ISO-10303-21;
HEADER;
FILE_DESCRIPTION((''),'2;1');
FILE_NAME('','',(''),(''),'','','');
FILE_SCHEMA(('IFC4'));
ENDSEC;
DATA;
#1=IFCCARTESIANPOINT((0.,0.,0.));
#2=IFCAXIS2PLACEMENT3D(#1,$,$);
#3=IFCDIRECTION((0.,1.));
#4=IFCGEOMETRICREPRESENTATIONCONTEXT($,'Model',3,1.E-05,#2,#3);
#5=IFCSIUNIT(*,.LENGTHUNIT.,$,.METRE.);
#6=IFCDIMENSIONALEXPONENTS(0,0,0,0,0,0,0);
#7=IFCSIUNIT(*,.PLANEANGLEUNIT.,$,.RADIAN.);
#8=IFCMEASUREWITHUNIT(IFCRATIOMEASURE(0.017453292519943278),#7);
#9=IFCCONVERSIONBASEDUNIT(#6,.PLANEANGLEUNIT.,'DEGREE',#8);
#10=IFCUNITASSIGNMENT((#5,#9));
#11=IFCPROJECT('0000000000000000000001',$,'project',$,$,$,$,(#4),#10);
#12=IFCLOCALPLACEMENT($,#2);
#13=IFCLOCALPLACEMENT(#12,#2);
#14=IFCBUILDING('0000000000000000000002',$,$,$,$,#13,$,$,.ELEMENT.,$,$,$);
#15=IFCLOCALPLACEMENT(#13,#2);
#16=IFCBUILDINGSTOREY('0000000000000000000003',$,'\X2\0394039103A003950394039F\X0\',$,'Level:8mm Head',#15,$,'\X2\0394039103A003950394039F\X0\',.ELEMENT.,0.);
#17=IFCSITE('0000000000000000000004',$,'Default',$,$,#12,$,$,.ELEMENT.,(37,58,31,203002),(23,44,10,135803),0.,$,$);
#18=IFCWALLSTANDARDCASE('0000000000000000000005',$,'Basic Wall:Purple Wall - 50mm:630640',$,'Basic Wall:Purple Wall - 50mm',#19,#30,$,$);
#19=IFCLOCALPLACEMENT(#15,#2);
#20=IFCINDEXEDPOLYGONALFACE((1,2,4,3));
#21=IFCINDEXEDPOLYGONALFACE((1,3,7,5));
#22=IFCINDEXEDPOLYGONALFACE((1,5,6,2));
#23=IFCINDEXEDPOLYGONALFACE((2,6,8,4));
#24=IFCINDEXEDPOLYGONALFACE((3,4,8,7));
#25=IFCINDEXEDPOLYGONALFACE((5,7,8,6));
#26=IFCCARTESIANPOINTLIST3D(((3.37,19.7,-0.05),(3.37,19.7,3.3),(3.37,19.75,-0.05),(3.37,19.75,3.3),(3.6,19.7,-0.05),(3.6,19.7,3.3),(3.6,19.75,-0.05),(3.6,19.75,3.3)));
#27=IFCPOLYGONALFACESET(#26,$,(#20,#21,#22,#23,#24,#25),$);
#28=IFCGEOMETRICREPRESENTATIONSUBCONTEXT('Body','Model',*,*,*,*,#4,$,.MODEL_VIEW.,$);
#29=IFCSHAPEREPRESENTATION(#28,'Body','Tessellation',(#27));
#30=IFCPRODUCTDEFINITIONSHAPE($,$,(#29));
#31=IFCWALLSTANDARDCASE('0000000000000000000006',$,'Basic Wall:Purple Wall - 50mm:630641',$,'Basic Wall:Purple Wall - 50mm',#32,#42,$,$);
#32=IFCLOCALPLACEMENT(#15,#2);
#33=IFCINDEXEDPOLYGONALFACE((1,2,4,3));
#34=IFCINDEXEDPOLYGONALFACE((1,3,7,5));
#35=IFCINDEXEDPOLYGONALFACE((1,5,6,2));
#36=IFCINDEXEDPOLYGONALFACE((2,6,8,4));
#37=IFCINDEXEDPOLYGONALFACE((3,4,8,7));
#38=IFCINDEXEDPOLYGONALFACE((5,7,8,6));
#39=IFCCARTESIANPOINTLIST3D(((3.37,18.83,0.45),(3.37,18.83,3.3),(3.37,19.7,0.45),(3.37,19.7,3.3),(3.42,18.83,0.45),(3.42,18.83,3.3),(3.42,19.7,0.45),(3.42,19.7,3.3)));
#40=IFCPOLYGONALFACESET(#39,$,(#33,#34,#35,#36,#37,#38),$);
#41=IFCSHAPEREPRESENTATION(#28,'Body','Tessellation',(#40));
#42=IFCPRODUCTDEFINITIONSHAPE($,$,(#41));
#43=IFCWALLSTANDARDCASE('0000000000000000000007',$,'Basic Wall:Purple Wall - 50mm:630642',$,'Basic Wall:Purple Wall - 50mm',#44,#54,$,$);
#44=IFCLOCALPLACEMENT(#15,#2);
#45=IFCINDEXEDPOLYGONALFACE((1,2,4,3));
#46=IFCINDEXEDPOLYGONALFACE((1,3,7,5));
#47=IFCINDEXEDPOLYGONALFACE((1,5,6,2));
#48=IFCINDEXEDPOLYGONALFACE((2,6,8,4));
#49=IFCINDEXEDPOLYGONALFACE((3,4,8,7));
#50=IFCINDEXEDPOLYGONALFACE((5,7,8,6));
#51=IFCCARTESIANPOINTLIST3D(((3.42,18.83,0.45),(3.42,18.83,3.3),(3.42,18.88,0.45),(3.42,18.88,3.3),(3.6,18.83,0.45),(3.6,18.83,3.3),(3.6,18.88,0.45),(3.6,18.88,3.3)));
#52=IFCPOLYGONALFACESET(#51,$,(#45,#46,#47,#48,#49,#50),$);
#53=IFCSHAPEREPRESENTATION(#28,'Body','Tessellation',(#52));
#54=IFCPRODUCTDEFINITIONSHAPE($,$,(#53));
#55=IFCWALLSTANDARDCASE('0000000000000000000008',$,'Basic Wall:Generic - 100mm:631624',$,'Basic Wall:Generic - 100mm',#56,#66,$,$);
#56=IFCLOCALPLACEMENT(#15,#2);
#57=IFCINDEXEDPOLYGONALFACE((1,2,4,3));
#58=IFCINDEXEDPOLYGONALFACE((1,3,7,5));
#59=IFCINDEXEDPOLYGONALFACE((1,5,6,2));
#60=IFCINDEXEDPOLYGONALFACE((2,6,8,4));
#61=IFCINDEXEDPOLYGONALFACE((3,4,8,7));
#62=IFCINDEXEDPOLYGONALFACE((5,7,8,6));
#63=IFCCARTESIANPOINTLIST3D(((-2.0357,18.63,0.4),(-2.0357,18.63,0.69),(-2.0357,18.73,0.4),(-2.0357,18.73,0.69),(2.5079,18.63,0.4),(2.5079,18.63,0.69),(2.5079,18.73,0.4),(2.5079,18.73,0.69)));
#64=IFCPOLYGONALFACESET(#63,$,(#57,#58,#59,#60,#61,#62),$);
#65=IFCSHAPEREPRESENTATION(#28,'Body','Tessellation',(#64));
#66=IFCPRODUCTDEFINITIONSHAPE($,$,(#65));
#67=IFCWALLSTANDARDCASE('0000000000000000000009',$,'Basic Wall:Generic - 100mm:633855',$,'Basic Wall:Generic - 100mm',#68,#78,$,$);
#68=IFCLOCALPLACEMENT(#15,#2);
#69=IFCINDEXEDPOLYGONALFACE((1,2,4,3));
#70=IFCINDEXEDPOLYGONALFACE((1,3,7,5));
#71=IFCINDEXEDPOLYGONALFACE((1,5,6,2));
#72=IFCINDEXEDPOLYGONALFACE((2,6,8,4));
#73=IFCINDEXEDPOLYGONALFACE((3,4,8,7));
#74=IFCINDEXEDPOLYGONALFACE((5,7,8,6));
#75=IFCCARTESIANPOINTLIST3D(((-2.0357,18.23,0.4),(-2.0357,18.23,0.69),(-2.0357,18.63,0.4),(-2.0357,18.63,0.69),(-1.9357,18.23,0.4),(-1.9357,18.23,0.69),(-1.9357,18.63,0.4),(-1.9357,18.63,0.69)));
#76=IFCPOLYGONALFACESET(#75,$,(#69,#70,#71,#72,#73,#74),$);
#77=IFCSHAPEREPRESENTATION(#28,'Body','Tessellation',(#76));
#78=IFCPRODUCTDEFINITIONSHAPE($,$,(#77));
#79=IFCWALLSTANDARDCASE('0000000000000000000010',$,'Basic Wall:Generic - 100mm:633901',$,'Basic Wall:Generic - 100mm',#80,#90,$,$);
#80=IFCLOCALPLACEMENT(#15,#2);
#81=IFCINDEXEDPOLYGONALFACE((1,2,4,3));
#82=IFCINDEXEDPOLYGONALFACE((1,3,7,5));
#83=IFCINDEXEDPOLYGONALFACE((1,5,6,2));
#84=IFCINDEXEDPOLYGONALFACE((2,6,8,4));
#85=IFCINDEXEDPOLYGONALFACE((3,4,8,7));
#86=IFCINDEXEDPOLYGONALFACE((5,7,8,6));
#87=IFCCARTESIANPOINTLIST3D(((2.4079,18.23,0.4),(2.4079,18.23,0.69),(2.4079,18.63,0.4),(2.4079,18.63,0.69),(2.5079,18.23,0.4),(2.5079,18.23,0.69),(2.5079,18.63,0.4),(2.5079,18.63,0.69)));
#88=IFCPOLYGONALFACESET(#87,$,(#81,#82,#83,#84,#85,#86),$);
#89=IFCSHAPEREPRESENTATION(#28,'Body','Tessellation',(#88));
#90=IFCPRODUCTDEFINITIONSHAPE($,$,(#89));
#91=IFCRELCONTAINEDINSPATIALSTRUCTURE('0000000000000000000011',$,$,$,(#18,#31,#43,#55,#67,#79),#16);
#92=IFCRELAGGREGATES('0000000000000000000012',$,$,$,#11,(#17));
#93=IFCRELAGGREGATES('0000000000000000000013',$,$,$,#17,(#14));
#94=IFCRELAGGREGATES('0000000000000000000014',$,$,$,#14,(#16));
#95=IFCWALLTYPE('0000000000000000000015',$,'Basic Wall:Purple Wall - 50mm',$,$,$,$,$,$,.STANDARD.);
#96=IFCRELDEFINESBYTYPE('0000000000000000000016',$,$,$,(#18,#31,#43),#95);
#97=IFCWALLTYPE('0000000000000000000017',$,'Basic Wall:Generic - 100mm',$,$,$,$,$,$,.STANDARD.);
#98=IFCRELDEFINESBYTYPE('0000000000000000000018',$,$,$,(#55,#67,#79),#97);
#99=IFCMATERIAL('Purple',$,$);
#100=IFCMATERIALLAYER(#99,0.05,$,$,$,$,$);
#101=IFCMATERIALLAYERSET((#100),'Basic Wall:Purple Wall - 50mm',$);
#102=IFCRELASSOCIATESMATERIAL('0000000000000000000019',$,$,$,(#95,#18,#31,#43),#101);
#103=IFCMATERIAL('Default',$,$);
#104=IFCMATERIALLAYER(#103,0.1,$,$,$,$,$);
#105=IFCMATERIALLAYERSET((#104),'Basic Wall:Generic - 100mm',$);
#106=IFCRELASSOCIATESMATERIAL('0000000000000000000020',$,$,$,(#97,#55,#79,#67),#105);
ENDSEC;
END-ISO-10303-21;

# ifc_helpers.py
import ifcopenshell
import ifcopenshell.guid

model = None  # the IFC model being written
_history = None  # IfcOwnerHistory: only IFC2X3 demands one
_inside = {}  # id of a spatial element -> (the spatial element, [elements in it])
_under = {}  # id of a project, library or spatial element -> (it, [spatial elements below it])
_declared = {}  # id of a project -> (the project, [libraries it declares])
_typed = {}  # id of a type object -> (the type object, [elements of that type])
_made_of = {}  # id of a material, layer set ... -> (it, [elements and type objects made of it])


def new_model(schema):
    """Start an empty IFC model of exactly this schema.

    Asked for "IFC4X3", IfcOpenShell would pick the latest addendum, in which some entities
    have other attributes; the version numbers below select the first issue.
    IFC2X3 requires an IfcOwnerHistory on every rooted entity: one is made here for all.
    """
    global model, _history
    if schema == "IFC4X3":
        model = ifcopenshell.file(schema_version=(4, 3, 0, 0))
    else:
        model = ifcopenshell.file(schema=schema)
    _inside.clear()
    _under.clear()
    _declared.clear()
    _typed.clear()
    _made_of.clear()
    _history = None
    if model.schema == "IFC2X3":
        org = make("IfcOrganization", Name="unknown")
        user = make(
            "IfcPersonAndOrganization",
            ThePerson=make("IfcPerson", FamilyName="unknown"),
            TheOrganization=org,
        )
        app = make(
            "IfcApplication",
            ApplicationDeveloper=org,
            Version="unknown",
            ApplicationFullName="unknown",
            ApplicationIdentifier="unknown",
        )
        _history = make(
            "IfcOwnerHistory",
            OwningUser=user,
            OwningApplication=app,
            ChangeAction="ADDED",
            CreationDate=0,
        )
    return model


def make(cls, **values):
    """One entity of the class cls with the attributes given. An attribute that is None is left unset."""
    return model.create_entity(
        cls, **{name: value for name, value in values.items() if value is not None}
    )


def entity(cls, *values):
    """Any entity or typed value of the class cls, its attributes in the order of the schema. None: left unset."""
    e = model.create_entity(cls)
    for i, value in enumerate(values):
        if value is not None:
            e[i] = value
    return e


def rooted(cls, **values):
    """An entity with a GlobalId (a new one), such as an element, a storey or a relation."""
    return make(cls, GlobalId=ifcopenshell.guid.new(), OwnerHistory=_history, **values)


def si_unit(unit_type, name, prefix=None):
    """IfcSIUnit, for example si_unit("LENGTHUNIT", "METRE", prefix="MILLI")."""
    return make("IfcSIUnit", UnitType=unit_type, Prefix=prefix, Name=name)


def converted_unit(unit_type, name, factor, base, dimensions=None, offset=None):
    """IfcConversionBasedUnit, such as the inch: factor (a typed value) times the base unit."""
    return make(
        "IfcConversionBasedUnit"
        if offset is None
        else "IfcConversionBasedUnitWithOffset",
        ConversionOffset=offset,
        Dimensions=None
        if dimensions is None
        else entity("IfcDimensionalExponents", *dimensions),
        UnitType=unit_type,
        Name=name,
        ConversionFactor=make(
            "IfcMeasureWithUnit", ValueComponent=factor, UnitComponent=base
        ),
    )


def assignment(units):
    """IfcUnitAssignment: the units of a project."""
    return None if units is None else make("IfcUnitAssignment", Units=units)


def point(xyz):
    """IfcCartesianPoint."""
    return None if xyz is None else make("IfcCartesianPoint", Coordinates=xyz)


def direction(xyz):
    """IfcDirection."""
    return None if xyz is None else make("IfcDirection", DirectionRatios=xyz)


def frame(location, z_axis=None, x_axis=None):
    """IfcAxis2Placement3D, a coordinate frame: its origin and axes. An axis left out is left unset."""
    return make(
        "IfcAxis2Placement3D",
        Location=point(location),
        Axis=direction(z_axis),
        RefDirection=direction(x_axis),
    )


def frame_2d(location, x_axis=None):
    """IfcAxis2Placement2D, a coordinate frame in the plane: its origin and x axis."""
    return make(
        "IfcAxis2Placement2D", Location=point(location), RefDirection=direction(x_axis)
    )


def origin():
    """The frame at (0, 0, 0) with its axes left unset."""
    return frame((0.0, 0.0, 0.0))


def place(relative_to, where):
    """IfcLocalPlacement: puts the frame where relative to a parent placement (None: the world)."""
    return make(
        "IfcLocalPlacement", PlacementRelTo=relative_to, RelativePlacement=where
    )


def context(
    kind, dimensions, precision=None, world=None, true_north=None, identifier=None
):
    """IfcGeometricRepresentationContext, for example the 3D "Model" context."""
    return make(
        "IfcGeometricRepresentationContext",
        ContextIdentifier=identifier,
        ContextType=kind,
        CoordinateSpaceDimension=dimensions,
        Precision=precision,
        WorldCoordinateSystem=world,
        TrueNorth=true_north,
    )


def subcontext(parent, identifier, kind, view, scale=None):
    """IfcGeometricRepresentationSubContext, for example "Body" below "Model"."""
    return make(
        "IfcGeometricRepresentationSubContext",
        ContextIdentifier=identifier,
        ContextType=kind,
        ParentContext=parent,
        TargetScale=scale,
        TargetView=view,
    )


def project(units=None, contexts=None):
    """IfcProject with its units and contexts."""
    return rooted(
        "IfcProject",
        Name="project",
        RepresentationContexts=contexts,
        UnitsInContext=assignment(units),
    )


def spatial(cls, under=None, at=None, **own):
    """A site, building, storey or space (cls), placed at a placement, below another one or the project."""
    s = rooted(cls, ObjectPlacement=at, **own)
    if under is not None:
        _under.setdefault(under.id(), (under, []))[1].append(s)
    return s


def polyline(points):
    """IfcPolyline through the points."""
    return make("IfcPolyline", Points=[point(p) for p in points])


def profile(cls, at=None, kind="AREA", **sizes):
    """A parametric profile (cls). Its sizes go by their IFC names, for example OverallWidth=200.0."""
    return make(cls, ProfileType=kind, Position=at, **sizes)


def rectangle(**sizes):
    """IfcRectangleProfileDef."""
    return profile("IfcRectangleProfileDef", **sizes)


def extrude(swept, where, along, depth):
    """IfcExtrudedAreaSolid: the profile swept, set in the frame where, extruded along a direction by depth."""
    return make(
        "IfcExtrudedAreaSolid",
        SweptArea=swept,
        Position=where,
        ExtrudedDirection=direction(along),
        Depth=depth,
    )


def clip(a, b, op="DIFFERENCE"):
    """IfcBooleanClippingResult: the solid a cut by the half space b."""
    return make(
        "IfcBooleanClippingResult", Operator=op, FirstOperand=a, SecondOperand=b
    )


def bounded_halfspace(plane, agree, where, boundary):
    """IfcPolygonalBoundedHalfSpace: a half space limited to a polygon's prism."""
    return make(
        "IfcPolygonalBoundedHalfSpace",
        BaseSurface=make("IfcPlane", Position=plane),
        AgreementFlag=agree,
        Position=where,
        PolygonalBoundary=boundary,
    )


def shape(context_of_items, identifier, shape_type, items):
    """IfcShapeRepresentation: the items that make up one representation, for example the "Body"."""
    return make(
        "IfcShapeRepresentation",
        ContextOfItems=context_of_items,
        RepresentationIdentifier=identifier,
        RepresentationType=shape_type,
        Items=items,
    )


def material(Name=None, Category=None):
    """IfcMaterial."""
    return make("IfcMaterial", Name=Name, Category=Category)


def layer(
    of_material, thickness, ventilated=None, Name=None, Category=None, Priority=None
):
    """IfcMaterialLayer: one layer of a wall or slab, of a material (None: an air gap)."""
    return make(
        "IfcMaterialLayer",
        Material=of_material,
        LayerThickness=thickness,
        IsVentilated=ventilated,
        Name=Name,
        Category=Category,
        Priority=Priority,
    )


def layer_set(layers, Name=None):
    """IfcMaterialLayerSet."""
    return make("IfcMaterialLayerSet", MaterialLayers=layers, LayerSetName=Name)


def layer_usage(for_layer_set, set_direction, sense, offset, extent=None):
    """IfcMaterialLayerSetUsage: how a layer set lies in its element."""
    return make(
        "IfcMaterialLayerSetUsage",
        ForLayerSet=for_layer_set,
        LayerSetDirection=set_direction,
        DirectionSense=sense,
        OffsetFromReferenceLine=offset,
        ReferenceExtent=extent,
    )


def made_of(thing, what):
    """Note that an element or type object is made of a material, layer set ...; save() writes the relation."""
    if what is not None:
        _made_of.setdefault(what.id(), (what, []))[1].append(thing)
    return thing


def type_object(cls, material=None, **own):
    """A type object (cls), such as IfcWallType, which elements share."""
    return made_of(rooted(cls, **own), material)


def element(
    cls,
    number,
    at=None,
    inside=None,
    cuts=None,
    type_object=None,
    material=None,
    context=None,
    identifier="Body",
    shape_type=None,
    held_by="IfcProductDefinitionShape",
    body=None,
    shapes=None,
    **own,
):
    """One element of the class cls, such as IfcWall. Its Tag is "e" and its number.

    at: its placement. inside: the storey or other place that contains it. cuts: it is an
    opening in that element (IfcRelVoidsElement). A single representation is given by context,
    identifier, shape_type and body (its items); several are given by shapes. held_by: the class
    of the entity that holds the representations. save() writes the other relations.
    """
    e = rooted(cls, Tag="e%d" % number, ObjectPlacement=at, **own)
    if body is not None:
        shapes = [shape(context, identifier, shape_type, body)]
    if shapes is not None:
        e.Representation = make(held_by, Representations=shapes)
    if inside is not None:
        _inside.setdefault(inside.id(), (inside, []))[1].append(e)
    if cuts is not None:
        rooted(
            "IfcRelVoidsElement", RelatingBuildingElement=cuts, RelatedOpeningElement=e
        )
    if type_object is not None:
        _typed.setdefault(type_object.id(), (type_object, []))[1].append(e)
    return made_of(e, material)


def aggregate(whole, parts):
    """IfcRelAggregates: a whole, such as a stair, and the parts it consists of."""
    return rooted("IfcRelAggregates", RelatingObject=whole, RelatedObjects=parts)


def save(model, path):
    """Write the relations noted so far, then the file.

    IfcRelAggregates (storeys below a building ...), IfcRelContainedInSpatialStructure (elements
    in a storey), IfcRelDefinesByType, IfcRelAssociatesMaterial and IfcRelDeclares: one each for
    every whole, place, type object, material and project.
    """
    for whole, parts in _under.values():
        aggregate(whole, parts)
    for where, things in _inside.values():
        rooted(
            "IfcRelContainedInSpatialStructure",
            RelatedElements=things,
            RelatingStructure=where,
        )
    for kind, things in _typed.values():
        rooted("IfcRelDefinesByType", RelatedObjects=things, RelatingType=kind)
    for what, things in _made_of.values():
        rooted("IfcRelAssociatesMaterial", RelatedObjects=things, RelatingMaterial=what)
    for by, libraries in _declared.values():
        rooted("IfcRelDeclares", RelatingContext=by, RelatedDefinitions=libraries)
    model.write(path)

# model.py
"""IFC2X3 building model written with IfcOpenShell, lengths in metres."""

from ifc_helpers import new_model, entity, si_unit, converted_unit, direction, frame, frame_2d, origin, place, context, subcontext, project, spatial, polyline, rectangle, extrude, clip, bounded_halfspace, material, layer, layer_set, layer_usage, type_object, element, save


model = new_model("IFC2X3")

# Units and contexts
model_context = context("Model", 3, precision=1e-05, world=origin(), true_north=direction((0.0, 1.0)))
body_context = subcontext(model_context, "Body", "Model", "MODEL_VIEW")
ifc_project = project(units=[si_unit("LENGTHUNIT", "METRE"), converted_unit("PLANEANGLEUNIT", "DEGREE", entity("IfcRatioMeasure", 0.017453292519943278), si_unit("PLANEANGLEUNIT", "RADIAN"), dimensions=[0, 0, 0, 0, 0, 0, 0])], contexts=[model_context])

# Site, building, storey
site_placement = place(None, origin())
site = spatial("IfcSite", under=ifc_project, at=site_placement, Name="Default", CompositionType="ELEMENT", RefLatitude=(37, 58, 31, 203002), RefLongitude=(23, 44, 10, 135803), RefElevation=0.0)
building_placement = place(site_placement, origin())
building = spatial("IfcBuilding", under=site, at=building_placement, CompositionType="ELEMENT")
storey_placement = place(building_placement, origin())
storey = spatial("IfcBuildingStorey", under=building, at=storey_placement, Name="ΔΑΠΕΔΟ", ObjectType="Level:8mm Head", LongName="ΔΑΠΕΔΟ", CompositionType="ELEMENT", Elevation=0.0)

# Shared definitions
ifc_material_1 = material(Name="Default")

# Walls
ifc_material_2 = material(Name="Purple")
ifc_layer_1 = layer(ifc_material_2, 0.05)
ifc_layer_set_1 = layer_set([ifc_layer_1], Name="Basic Wall:Purple Wall - 50mm")
ifc_layer_usage_1 = layer_usage(ifc_layer_set_1, "AXIS2", "POSITIVE", -0.025)
wall_type_1 = type_object("IfcWallType", Name="Basic Wall:Purple Wall - 50mm", PredefinedType="STANDARD", material=ifc_layer_set_1)
wall_1_placement = place(storey_placement, frame((3.6, 19.725, -0.05), z_axis=(0.0, 0.0, 1.0), x_axis=(-1.0, 0.0, 0.0)))
element("IfcWallStandardCase", 1, at=wall_1_placement, inside=storey, type_object=wall_type_1, material=ifc_layer_usage_1, Name="Basic Wall:Purple Wall - 50mm:630640", ObjectType="Basic Wall:Purple Wall - 50mm", context=body_context, shape_type="Clipping", body=[
    clip(extrude(rectangle(XDim=0.23, YDim=0.05, at=frame_2d((0.115, 0.0), x_axis=(-1.0, 0.0))), origin(), (0.0, 0.0, 1.0), 3.35), bounded_halfspace(frame((0.23, -0.025, 0.0), z_axis=(0.0, 0.0, 1.0), x_axis=(0.0, -1.0, 0.0)), True, frame((0.23, -0.025, 0.0), z_axis=(0.0, 0.0, 1.0), x_axis=(0.0, -1.0, 0.0)), polyline([(0.0, 0.0), (-0.05, 0.0), (-0.05, -0.23), (0.0, -0.23), (0.0, 0.0)]))),
])
wall_2_placement = place(storey_placement, frame((3.395, 19.7, 0.45), z_axis=(0.0, 0.0, 1.0), x_axis=(0.0, -1.0, 0.0)))
element("IfcWallStandardCase", 2, at=wall_2_placement, inside=storey, type_object=wall_type_1, material=ifc_layer_usage_1, Name="Basic Wall:Purple Wall - 50mm:630641", ObjectType="Basic Wall:Purple Wall - 50mm", context=body_context, shape_type="SweptSolid", body=[
    extrude(rectangle(XDim=0.87, YDim=0.05, at=frame_2d((0.435, 0.0), x_axis=(-1.0, 0.0))), origin(), (0.0, 0.0, 1.0), 2.85),
])
wall_3_placement = place(storey_placement, frame((3.42, 18.855, 0.45)))
element("IfcWallStandardCase", 3, at=wall_3_placement, inside=storey, type_object=wall_type_1, material=ifc_layer_usage_1, Name="Basic Wall:Purple Wall - 50mm:630642", ObjectType="Basic Wall:Purple Wall - 50mm", context=body_context, shape_type="SweptSolid", body=[
    extrude(rectangle(XDim=0.18, YDim=0.05, at=frame_2d((0.09, 0.0), x_axis=(-1.0, 0.0))), origin(), (0.0, 0.0, 1.0), 2.85),
])
ifc_layer_2 = layer(ifc_material_1, 0.1)
ifc_layer_set_2 = layer_set([ifc_layer_2], Name="Basic Wall:Generic - 100mm")
ifc_layer_usage_2 = layer_usage(ifc_layer_set_2, "AXIS2", "NEGATIVE", 0.05)
wall_type_2 = type_object("IfcWallType", Name="Basic Wall:Generic - 100mm", PredefinedType="STANDARD", material=ifc_layer_set_2)
wall_4_placement = place(storey_placement, frame((-2.0357, 18.68, 0.4)))
element("IfcWallStandardCase", 4, at=wall_4_placement, inside=storey, type_object=wall_type_2, material=ifc_layer_usage_2, Name="Basic Wall:Generic - 100mm:631624", ObjectType="Basic Wall:Generic - 100mm", context=body_context, shape_type="SweptSolid", body=[
    extrude(rectangle(XDim=4.5435, YDim=0.1, at=frame_2d((2.2718, 0.0), x_axis=(-1.0, 0.0))), origin(), (0.0, 0.0, 1.0), 0.29),
])
ifc_layer_usage_3 = layer_usage(ifc_layer_set_2, "AXIS2", "POSITIVE", -0.05)
wall_5_placement = place(storey_placement, frame((-1.9857, 18.63, 0.4), z_axis=(0.0, 0.0, 1.0), x_axis=(0.0, -1.0, 0.0)))
element("IfcWallStandardCase", 5, at=wall_5_placement, inside=storey, type_object=wall_type_2, material=ifc_layer_usage_3, Name="Basic Wall:Generic - 100mm:633855", ObjectType="Basic Wall:Generic - 100mm", context=body_context, shape_type="SweptSolid", body=[
    extrude(rectangle(XDim=0.4, YDim=0.1, at=frame_2d((0.2, 0.0), x_axis=(-1.0, 0.0))), origin(), (0.0, 0.0, 1.0), 0.29),
])
wall_6_placement = place(storey_placement, frame((2.4579, 18.63, 0.4), z_axis=(0.0, 0.0, 1.0), x_axis=(0.0, -1.0, 0.0)))
element("IfcWallStandardCase", 6, at=wall_6_placement, inside=storey, type_object=wall_type_2, material=ifc_layer_usage_2, Name="Basic Wall:Generic - 100mm:633901", ObjectType="Basic Wall:Generic - 100mm", context=body_context, shape_type="SweptSolid", body=[
    extrude(rectangle(XDim=0.4, YDim=0.1, at=frame_2d((0.2, 0.0), x_axis=(-1.0, 0.0))), origin(), (0.0, 0.0, 1.0), 0.29),
])

save(model, "model.ifc")
